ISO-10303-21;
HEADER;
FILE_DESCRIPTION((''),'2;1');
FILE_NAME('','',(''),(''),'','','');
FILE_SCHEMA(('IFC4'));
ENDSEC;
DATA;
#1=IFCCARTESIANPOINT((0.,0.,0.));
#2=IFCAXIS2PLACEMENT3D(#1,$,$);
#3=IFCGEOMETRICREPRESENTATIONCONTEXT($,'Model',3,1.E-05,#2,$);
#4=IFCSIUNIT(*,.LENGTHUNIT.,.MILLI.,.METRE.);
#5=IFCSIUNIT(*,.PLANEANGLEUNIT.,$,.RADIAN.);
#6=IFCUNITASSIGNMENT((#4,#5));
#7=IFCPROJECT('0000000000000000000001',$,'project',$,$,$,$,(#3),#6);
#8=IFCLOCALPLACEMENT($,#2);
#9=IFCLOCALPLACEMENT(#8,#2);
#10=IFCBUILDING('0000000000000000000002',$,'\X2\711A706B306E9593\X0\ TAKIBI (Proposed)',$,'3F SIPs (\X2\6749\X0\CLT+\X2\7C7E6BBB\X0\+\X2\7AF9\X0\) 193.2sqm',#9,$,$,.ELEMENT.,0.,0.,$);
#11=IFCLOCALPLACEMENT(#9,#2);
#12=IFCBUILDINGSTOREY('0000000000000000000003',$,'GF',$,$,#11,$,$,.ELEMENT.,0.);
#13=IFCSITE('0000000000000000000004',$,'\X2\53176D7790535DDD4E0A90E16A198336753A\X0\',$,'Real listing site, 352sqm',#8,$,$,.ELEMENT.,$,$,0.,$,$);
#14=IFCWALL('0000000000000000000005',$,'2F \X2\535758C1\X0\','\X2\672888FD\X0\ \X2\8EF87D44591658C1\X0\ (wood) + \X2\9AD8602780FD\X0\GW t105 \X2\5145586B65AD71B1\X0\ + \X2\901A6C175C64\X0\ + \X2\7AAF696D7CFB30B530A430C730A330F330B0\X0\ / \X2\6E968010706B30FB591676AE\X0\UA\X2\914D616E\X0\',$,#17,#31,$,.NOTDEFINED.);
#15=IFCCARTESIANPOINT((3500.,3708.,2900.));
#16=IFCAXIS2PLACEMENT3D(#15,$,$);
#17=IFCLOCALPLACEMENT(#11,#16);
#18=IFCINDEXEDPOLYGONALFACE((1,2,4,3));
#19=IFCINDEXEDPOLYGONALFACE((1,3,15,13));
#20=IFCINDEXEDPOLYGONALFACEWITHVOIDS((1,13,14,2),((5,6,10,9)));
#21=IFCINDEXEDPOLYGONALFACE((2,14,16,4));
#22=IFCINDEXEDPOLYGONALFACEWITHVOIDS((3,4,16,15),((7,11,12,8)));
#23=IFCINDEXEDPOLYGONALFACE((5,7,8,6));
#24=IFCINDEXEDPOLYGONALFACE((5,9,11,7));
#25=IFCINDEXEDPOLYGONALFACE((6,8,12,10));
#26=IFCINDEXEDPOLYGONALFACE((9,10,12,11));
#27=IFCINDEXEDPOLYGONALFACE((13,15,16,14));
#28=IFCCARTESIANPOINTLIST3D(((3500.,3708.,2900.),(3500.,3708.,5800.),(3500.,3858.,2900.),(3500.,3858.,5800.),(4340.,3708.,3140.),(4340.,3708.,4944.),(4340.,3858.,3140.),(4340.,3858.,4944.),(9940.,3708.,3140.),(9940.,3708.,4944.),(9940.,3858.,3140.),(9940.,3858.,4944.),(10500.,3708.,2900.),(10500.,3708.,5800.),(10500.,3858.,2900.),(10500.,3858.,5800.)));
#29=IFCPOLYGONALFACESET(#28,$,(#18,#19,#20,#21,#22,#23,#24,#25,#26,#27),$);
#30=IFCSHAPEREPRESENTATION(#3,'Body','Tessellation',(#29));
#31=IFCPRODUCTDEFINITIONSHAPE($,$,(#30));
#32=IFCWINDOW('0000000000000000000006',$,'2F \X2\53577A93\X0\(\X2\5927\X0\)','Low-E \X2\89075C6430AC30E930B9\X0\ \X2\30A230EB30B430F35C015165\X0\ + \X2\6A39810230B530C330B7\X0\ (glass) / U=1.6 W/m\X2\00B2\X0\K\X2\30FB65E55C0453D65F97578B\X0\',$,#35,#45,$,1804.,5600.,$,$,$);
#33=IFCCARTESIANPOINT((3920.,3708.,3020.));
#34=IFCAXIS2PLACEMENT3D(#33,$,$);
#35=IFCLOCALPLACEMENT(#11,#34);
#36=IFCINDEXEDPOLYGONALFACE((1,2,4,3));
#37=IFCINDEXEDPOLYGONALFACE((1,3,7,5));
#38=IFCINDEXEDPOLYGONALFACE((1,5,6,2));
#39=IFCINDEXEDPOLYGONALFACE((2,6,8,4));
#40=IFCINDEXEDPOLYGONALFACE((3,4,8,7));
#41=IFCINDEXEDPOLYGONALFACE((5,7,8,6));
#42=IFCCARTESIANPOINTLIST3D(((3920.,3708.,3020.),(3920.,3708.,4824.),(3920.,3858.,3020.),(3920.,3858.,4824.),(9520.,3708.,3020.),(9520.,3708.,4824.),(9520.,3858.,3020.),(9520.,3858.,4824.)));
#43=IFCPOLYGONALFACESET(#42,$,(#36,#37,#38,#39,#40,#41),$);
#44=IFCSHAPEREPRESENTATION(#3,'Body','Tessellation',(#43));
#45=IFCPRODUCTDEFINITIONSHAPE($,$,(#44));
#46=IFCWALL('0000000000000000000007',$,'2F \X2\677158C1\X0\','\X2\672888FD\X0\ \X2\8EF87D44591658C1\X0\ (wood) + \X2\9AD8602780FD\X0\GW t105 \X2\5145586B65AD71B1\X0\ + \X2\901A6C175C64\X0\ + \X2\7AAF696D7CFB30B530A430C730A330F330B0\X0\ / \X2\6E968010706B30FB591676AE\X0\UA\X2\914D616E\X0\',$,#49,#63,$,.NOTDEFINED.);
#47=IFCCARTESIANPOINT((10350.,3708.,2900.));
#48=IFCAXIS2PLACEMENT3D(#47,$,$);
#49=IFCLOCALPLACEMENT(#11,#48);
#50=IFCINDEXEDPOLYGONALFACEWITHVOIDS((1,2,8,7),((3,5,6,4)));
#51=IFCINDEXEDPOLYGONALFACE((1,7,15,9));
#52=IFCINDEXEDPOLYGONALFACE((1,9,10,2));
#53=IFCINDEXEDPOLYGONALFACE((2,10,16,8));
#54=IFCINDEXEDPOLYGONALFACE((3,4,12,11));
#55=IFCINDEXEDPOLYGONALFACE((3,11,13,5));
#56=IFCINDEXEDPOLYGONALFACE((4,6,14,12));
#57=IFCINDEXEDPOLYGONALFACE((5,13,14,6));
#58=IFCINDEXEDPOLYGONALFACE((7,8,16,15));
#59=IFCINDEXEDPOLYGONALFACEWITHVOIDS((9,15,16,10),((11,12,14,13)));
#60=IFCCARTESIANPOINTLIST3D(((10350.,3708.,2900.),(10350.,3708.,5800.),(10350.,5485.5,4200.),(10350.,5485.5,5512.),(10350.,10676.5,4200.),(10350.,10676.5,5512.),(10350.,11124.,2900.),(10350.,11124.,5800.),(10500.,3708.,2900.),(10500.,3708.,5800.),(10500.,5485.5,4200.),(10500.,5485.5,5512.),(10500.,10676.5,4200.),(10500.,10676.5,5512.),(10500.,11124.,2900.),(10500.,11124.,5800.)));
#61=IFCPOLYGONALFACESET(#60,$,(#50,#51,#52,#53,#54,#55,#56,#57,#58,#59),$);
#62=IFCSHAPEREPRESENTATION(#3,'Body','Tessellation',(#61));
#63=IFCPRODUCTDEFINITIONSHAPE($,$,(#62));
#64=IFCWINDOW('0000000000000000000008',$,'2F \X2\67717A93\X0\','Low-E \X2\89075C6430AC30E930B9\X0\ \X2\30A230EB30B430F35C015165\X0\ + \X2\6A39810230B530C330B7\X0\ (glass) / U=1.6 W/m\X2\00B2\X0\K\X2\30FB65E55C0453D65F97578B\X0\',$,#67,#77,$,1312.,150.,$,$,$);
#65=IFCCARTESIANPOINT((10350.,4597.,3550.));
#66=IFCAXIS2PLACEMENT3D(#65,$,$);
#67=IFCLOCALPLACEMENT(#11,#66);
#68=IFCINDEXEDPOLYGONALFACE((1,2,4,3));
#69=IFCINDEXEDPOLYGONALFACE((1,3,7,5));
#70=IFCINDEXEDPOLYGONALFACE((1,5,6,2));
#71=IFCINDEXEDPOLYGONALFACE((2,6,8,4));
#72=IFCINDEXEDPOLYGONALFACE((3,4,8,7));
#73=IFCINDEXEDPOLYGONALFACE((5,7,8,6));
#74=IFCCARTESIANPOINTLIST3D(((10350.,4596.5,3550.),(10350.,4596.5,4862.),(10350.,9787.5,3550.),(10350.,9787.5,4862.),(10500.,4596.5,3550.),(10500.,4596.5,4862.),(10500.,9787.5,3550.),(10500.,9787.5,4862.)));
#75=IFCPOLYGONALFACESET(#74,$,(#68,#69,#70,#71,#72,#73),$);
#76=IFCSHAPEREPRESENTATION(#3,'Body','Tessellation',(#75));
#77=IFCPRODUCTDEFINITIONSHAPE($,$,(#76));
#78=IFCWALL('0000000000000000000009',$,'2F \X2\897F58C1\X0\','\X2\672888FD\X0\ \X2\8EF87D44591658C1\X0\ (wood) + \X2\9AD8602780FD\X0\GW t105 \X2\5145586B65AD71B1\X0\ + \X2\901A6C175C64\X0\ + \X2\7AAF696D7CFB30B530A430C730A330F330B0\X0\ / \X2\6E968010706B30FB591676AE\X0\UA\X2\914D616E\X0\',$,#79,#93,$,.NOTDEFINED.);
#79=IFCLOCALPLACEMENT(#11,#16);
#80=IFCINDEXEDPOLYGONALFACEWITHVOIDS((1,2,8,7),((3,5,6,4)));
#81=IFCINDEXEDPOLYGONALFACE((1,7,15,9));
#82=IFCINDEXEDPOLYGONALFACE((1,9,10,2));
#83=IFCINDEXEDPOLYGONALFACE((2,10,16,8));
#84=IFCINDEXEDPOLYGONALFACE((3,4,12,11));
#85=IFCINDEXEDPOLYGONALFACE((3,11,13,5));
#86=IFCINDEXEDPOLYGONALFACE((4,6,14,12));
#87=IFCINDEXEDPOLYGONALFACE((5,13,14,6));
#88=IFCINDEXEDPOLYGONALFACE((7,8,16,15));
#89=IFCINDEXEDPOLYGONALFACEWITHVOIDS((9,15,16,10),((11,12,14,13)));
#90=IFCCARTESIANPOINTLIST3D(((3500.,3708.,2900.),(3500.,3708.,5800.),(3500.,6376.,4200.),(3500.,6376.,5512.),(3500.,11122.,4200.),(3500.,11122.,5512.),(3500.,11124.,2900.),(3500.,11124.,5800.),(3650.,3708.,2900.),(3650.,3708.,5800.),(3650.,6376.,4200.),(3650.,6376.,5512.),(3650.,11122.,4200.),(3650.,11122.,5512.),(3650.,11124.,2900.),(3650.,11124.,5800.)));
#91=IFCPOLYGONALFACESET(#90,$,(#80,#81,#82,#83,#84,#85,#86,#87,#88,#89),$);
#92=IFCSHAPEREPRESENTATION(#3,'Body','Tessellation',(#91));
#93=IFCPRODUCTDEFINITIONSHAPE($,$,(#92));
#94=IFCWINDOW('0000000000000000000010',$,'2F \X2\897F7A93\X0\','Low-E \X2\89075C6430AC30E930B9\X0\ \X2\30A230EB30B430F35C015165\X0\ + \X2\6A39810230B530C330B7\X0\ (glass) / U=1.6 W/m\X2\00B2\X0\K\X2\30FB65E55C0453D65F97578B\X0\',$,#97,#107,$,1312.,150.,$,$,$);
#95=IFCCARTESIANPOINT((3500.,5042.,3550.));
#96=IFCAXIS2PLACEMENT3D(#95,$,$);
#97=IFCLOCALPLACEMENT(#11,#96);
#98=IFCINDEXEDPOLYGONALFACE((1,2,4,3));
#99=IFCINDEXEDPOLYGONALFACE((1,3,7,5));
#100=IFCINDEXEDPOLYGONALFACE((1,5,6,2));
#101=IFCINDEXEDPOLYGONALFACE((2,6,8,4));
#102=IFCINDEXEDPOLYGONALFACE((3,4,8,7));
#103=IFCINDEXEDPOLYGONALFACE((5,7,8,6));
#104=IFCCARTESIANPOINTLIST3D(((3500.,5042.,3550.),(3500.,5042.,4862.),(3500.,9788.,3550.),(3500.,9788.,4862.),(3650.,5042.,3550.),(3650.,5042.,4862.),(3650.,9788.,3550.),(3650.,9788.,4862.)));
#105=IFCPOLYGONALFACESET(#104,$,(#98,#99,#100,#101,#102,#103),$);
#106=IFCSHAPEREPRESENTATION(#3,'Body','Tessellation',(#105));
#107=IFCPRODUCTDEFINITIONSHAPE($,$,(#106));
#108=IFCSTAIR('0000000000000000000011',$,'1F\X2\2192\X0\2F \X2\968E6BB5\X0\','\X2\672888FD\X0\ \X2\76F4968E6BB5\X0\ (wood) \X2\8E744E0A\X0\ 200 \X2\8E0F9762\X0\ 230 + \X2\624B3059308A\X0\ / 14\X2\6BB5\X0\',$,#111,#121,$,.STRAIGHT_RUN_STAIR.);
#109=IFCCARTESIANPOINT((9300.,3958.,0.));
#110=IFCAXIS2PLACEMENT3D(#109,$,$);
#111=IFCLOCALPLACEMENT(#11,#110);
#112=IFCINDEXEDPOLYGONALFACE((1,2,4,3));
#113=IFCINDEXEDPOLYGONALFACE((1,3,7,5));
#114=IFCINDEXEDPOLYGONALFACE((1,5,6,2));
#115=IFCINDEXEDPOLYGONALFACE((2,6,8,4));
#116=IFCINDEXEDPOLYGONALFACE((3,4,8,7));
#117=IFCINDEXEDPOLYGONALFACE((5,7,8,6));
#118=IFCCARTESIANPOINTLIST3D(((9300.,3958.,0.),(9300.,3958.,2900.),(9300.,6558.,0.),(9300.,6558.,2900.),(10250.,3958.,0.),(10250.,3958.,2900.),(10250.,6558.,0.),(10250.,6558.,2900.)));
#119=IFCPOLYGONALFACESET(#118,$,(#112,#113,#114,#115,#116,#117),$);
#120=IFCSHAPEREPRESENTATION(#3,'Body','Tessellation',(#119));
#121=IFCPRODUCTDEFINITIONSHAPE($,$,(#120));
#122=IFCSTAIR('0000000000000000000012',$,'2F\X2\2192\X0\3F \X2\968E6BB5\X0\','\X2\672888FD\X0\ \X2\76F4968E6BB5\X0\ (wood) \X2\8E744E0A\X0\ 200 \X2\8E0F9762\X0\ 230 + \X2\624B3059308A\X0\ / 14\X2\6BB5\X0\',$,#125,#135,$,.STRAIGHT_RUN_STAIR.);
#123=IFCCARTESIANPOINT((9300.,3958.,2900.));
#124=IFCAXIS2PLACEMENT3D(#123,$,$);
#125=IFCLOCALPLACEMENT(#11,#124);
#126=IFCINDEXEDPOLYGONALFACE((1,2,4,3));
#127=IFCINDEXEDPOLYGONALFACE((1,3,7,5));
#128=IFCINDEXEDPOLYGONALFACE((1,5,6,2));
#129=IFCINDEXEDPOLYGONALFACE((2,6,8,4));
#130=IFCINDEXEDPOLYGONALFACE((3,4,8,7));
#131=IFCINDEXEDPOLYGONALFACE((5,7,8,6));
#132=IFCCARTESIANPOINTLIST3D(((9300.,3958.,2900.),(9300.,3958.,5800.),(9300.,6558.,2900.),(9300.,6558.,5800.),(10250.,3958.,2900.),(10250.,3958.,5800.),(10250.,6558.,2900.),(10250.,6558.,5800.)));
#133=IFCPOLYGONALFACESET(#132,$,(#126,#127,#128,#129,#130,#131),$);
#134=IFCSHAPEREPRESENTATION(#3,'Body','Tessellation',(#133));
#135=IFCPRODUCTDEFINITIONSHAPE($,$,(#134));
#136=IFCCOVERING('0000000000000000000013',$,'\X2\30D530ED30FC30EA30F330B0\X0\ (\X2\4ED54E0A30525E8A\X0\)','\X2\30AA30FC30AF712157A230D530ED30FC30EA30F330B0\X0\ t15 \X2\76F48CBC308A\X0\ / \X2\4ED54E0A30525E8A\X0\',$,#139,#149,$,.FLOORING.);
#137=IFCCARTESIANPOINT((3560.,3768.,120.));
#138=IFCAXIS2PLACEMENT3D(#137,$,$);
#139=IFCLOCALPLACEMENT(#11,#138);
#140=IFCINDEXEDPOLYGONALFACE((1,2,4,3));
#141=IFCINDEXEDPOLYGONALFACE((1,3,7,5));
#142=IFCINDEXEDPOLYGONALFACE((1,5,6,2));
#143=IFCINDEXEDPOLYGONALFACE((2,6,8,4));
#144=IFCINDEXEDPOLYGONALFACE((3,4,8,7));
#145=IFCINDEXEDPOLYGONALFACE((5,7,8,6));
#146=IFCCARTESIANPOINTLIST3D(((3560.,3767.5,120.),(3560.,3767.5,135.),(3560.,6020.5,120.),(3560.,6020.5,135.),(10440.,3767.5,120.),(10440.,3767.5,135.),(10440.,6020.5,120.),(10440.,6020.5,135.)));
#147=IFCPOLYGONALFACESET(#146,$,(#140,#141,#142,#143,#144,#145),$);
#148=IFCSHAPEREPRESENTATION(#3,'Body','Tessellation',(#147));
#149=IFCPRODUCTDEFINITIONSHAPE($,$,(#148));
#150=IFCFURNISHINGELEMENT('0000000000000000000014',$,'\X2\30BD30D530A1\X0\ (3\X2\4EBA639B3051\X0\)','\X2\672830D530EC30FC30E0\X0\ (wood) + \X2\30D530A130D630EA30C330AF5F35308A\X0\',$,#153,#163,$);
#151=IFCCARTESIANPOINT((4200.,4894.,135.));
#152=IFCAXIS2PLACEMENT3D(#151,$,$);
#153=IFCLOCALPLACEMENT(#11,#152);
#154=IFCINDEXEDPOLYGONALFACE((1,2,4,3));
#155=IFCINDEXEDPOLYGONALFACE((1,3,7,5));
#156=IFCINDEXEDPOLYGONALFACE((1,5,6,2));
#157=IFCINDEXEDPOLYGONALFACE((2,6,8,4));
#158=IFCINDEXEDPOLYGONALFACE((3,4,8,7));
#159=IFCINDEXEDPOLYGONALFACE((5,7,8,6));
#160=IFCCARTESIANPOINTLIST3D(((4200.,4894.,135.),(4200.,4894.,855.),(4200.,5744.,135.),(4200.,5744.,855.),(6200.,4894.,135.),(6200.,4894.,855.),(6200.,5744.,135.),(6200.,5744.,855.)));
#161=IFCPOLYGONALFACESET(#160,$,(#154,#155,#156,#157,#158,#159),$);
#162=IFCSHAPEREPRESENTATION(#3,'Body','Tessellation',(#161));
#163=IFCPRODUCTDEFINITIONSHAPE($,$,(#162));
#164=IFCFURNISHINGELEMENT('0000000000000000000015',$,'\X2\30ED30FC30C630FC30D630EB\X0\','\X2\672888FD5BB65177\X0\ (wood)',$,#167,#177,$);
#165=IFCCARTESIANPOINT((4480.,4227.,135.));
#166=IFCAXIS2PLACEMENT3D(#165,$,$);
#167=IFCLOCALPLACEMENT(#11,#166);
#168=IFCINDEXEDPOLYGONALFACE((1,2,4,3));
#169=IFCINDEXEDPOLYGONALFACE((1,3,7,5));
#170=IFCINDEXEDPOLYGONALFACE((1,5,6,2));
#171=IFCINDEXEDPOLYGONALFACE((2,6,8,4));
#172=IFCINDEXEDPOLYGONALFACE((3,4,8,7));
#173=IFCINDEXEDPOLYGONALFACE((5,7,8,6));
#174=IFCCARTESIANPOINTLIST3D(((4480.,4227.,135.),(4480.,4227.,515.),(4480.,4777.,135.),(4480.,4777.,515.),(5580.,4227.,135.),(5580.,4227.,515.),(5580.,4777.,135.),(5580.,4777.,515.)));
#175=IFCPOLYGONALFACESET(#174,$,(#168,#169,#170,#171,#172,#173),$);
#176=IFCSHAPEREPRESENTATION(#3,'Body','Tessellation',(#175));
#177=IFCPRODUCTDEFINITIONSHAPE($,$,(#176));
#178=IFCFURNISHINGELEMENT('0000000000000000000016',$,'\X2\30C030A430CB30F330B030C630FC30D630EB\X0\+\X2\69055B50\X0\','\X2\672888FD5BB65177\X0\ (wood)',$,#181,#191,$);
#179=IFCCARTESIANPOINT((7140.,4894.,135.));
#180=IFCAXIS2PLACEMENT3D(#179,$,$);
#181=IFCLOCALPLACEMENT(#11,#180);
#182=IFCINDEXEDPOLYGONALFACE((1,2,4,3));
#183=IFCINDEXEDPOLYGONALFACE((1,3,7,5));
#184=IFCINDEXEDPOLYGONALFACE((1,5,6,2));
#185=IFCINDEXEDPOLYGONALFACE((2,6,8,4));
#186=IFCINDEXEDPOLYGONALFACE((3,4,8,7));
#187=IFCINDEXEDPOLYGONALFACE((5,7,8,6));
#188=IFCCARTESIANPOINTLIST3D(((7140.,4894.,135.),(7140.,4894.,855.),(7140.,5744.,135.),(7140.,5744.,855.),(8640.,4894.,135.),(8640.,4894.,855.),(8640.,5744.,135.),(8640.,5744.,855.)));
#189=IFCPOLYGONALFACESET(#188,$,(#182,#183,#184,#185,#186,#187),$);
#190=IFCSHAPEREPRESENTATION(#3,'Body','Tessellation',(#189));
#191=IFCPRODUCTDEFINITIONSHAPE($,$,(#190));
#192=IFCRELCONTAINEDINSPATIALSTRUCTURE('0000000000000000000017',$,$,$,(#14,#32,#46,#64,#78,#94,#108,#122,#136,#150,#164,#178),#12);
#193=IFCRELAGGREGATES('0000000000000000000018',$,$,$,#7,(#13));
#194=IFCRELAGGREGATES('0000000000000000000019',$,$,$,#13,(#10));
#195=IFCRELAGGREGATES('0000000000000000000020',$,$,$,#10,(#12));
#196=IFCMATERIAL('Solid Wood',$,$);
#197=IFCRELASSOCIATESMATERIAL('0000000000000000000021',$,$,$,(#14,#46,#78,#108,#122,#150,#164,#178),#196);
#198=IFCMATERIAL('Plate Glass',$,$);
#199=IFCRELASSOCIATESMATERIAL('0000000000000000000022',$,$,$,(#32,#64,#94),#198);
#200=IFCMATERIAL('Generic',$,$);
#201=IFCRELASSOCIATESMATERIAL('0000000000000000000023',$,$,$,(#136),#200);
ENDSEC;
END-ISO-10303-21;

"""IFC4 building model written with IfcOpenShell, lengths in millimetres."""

from ifc_helpers import new_model, si_unit, frame, frame_2d, origin, place, context, project, spatial, rectangle, extrude, material, element, fill, save


model = new_model("IFC4")

# Units and contexts
model_context = context("Model", 3, precision=1e-05, world=origin())
ifc_project = project(units=[si_unit("LENGTHUNIT", "METRE", prefix="MILLI"), si_unit("PLANEANGLEUNIT", "RADIAN")], contexts=[model_context])

# Site, building, storey
site_placement = place(None, origin())
site = spatial("IfcSite", under=ifc_project, at=site_placement, Name="北海道川上郡標茶町", ObjectType="Real listing site, 352sqm", CompositionType="ELEMENT", RefElevation=0.0)
building_placement = place(site_placement, origin())
building = spatial("IfcBuilding", under=site, at=building_placement, Name="焚火の間 TAKIBI (Proposed)", ObjectType="3F SIPs (杉CLT+籾殻+竹) 193.2sqm", CompositionType="ELEMENT", ElevationOfRefHeight=0.0, ElevationOfTerrain=0.0)
storey_placement = place(building_placement, origin())
storey = spatial("IfcBuildingStorey", under=building, at=storey_placement, Name="GF", CompositionType="ELEMENT", Elevation=0.0)

# Shared definitions
ifc_material_1 = material(Name="Solid Wood")

# Shared definitions
ifc_material_2 = material(Name="Plate Glass")

# Walls, openings, windows
wall_1_placement = place(storey_placement, frame((3500.0, 3708.0, 2900.0)))
wall_1 = element("IfcWall", 1, at=wall_1_placement, inside=storey, material=ifc_material_1, Name="2F 南壁", Description="木製 軸組外壁 (wood) + 高性能GW t105 充填断熱 + 通気層 + 窯業系サイディング / 準耐火・外皮UA配慮", PredefinedType="NOTDEFINED", context=model_context, shape_type="SweptSolid", body=[
    extrude(rectangle(XDim=7000.0, YDim=150.0, at=frame_2d((3500.0, 75.0))), frame((3500.0, 3708.0, 2900.0)), (0.0, 0.0, 1.0), 2900.0),
])
opening_1_placement = place(storey_placement, frame((3920.0, 3708.0, 3020.0)))
opening_1 = element("IfcOpeningElement", 2, at=opening_1_placement, cuts=wall_1, PredefinedType="NOTDEFINED", context=model_context, shape_type="SweptSolid", body=[
    extrude(rectangle(XDim=5600.0, YDim=150.0, at=frame_2d((2800.0, 75.0))), frame((3920.0, 3708.0, 3020.0)), (0.0, 0.0, 1.0), 1804.0),
])
window_1_placement = place(storey_placement, frame((3920.0, 3708.0, 3020.0)))
window_1 = element("IfcWindow", 3, at=window_1_placement, inside=storey, material=ifc_material_2, Name="2F 南窓(大)", Description="Low-E 複層ガラス アルゴン封入 + 樹脂サッシ (glass) / U=1.6 W/m²K・日射取得型", OverallHeight=1804.0, OverallWidth=5600.0, context=model_context, shape_type="SweptSolid", body=[
    extrude(rectangle(XDim=5600.0, YDim=150.0, at=frame_2d((2800.0, 75.0))), frame((3920.0, 3708.0, 3020.0)), (0.0, 0.0, 1.0), 1804.0),
])
fill(opening_1, window_1)
wall_2_placement = place(storey_placement, frame((10350.0, 3708.0, 2900.0)))
wall_2 = element("IfcWall", 4, at=wall_2_placement, inside=storey, material=ifc_material_1, Name="2F 東壁", Description="木製 軸組外壁 (wood) + 高性能GW t105 充填断熱 + 通気層 + 窯業系サイディング / 準耐火・外皮UA配慮", PredefinedType="NOTDEFINED", context=model_context, shape_type="SweptSolid", body=[
    extrude(rectangle(XDim=150.0, YDim=7416.0, at=frame_2d((75.0, 3708.0))), frame((10350.0, 3708.0, 2900.0)), (0.0, 0.0, 1.0), 2900.0),
])
opening_2_placement = place(storey_placement, frame((10350.0, 4597.0, 3550.0)))
opening_2 = element("IfcOpeningElement", 5, at=opening_2_placement, cuts=wall_2, PredefinedType="NOTDEFINED", context=model_context, shape_type="SweptSolid", body=[
    extrude(rectangle(XDim=150.0, YDim=5191.0, at=frame_2d((75.0, 2595.0))), frame((10350.0, 4597.0, 3550.0)), (0.0, 0.0, 1.0), 1312.0),
])
window_2_placement = place(storey_placement, frame((10350.0, 4597.0, 3550.0)))
window_2 = element("IfcWindow", 6, at=window_2_placement, inside=storey, material=ifc_material_2, Name="2F 東窓", Description="Low-E 複層ガラス アルゴン封入 + 樹脂サッシ (glass) / U=1.6 W/m²K・日射取得型", OverallHeight=1312.0, OverallWidth=150.0, context=model_context, shape_type="SweptSolid", body=[
    extrude(rectangle(XDim=150.0, YDim=5191.0, at=frame_2d((75.0, 2595.0))), frame((10350.0, 4597.0, 3550.0)), (0.0, 0.0, 1.0), 1312.0),
])
fill(opening_2, window_2)
wall_3_placement = place(storey_placement, frame((3500.0, 3708.0, 2900.0)))
wall_3 = element("IfcWall", 7, at=wall_3_placement, inside=storey, material=ifc_material_1, Name="2F 西壁", Description="木製 軸組外壁 (wood) + 高性能GW t105 充填断熱 + 通気層 + 窯業系サイディング / 準耐火・外皮UA配慮", PredefinedType="NOTDEFINED", context=model_context, shape_type="SweptSolid", body=[
    extrude(rectangle(XDim=150.0, YDim=7416.0, at=frame_2d((75.0, 3708.0))), frame((3500.0, 3708.0, 2900.0)), (0.0, 0.0, 1.0), 2900.0),
])
opening_3_placement = place(storey_placement, frame((3500.0, 5042.0, 3550.0)))
opening_3 = element("IfcOpeningElement", 8, at=opening_3_placement, cuts=wall_3, PredefinedType="NOTDEFINED", context=model_context, shape_type="SweptSolid", body=[
    extrude(rectangle(XDim=150.0, YDim=4746.0, at=frame_2d((75.0, 2373.0))), frame((3500.0, 5042.0, 3550.0)), (0.0, 0.0, 1.0), 1312.0),
])
window_3_placement = place(storey_placement, frame((3500.0, 5042.0, 3550.0)))
window_3 = element("IfcWindow", 9, at=window_3_placement, inside=storey, material=ifc_material_2, Name="2F 西窓", Description="Low-E 複層ガラス アルゴン封入 + 樹脂サッシ (glass) / U=1.6 W/m²K・日射取得型", OverallHeight=1312.0, OverallWidth=150.0, context=model_context, shape_type="SweptSolid", body=[
    extrude(rectangle(XDim=150.0, YDim=4746.0, at=frame_2d((75.0, 2373.0))), frame((3500.0, 5042.0, 3550.0)), (0.0, 0.0, 1.0), 1312.0),
])
fill(opening_3, window_3)

# Stairs
stair_1_placement = place(storey_placement, frame((9300.0, 3958.0, 0.0)))
element("IfcStair", 10, at=stair_1_placement, inside=storey, material=ifc_material_1, Name="1F→2F 階段", Description="木製 直階段 (wood) 蹴上 200 踏面 230 + 手すり / 14段", PredefinedType="STRAIGHT_RUN_STAIR", context=model_context, shape_type="SweptSolid", body=[
    extrude(rectangle(XDim=950.0, YDim=2600.0, at=frame_2d((475.0, 1300.0))), frame((9300.0, 3958.0, 0.0)), (0.0, 0.0, 1.0), 2900.0),
])
stair_2_placement = place(storey_placement, frame((9300.0, 3958.0, 2900.0)))
element("IfcStair", 11, at=stair_2_placement, inside=storey, material=ifc_material_1, Name="2F→3F 階段", Description="木製 直階段 (wood) 蹴上 200 踏面 230 + 手すり / 14段", PredefinedType="STRAIGHT_RUN_STAIR", context=model_context, shape_type="SweptSolid", body=[
    extrude(rectangle(XDim=950.0, YDim=2600.0, at=frame_2d((475.0, 1300.0))), frame((9300.0, 3958.0, 2900.0)), (0.0, 0.0, 1.0), 2900.0),
])

# Covering
ifc_material_3 = material(Name="Generic")
covering_placement = place(storey_placement, frame((3560.0, 3768.0, 120.0)))
element("IfcCovering", 12, at=covering_placement, inside=storey, material=ifc_material_3, Name="フローリング (仕上げ床)", Description="オーク無垢フローリング t15 直貼り / 仕上げ床", PredefinedType="FLOORING", context=model_context, shape_type="SweptSolid", body=[
    extrude(rectangle(XDim=6880.0, YDim=2253.0, at=frame_2d((3440.0, 1126.0))), frame((3560.0, 3768.0, 120.0)), (0.0, 0.0, 1.0), 15.0),
])

# Furnishing elements
furnishing_1_placement = place(storey_placement, frame((4200.0, 4894.0, 135.0)))
element("IfcFurnishingElement", 13, at=furnishing_1_placement, inside=storey, material=ifc_material_1, Name="ソファ (3人掛け)", Description="木フレーム (wood) + ファブリック張り", context=model_context, shape_type="SweptSolid", body=[
    extrude(rectangle(XDim=2000.0, YDim=850.0, at=frame_2d((1000.0, 425.0))), frame((4200.0, 4894.0, 135.0)), (0.0, 0.0, 1.0), 720.0),
])
furnishing_2_placement = place(storey_placement, frame((4480.0, 4227.0, 135.0)))
element("IfcFurnishingElement", 14, at=furnishing_2_placement, inside=storey, material=ifc_material_1, Name="ローテーブル", Description="木製家具 (wood)", context=model_context, shape_type="SweptSolid", body=[
    extrude(rectangle(XDim=1100.0, YDim=550.0, at=frame_2d((550.0, 275.0))), frame((4480.0, 4227.0, 135.0)), (0.0, 0.0, 1.0), 380.0),
])
furnishing_3_placement = place(storey_placement, frame((7140.0, 4894.0, 135.0)))
element("IfcFurnishingElement", 15, at=furnishing_3_placement, inside=storey, material=ifc_material_1, Name="ダイニングテーブル+椅子", Description="木製家具 (wood)", context=model_context, shape_type="SweptSolid", body=[
    extrude(rectangle(XDim=1500.0, YDim=850.0, at=frame_2d((750.0, 425.0))), frame((7140.0, 4894.0, 135.0)), (0.0, 0.0, 1.0), 720.0),
])

save(model, "model.ifc")
